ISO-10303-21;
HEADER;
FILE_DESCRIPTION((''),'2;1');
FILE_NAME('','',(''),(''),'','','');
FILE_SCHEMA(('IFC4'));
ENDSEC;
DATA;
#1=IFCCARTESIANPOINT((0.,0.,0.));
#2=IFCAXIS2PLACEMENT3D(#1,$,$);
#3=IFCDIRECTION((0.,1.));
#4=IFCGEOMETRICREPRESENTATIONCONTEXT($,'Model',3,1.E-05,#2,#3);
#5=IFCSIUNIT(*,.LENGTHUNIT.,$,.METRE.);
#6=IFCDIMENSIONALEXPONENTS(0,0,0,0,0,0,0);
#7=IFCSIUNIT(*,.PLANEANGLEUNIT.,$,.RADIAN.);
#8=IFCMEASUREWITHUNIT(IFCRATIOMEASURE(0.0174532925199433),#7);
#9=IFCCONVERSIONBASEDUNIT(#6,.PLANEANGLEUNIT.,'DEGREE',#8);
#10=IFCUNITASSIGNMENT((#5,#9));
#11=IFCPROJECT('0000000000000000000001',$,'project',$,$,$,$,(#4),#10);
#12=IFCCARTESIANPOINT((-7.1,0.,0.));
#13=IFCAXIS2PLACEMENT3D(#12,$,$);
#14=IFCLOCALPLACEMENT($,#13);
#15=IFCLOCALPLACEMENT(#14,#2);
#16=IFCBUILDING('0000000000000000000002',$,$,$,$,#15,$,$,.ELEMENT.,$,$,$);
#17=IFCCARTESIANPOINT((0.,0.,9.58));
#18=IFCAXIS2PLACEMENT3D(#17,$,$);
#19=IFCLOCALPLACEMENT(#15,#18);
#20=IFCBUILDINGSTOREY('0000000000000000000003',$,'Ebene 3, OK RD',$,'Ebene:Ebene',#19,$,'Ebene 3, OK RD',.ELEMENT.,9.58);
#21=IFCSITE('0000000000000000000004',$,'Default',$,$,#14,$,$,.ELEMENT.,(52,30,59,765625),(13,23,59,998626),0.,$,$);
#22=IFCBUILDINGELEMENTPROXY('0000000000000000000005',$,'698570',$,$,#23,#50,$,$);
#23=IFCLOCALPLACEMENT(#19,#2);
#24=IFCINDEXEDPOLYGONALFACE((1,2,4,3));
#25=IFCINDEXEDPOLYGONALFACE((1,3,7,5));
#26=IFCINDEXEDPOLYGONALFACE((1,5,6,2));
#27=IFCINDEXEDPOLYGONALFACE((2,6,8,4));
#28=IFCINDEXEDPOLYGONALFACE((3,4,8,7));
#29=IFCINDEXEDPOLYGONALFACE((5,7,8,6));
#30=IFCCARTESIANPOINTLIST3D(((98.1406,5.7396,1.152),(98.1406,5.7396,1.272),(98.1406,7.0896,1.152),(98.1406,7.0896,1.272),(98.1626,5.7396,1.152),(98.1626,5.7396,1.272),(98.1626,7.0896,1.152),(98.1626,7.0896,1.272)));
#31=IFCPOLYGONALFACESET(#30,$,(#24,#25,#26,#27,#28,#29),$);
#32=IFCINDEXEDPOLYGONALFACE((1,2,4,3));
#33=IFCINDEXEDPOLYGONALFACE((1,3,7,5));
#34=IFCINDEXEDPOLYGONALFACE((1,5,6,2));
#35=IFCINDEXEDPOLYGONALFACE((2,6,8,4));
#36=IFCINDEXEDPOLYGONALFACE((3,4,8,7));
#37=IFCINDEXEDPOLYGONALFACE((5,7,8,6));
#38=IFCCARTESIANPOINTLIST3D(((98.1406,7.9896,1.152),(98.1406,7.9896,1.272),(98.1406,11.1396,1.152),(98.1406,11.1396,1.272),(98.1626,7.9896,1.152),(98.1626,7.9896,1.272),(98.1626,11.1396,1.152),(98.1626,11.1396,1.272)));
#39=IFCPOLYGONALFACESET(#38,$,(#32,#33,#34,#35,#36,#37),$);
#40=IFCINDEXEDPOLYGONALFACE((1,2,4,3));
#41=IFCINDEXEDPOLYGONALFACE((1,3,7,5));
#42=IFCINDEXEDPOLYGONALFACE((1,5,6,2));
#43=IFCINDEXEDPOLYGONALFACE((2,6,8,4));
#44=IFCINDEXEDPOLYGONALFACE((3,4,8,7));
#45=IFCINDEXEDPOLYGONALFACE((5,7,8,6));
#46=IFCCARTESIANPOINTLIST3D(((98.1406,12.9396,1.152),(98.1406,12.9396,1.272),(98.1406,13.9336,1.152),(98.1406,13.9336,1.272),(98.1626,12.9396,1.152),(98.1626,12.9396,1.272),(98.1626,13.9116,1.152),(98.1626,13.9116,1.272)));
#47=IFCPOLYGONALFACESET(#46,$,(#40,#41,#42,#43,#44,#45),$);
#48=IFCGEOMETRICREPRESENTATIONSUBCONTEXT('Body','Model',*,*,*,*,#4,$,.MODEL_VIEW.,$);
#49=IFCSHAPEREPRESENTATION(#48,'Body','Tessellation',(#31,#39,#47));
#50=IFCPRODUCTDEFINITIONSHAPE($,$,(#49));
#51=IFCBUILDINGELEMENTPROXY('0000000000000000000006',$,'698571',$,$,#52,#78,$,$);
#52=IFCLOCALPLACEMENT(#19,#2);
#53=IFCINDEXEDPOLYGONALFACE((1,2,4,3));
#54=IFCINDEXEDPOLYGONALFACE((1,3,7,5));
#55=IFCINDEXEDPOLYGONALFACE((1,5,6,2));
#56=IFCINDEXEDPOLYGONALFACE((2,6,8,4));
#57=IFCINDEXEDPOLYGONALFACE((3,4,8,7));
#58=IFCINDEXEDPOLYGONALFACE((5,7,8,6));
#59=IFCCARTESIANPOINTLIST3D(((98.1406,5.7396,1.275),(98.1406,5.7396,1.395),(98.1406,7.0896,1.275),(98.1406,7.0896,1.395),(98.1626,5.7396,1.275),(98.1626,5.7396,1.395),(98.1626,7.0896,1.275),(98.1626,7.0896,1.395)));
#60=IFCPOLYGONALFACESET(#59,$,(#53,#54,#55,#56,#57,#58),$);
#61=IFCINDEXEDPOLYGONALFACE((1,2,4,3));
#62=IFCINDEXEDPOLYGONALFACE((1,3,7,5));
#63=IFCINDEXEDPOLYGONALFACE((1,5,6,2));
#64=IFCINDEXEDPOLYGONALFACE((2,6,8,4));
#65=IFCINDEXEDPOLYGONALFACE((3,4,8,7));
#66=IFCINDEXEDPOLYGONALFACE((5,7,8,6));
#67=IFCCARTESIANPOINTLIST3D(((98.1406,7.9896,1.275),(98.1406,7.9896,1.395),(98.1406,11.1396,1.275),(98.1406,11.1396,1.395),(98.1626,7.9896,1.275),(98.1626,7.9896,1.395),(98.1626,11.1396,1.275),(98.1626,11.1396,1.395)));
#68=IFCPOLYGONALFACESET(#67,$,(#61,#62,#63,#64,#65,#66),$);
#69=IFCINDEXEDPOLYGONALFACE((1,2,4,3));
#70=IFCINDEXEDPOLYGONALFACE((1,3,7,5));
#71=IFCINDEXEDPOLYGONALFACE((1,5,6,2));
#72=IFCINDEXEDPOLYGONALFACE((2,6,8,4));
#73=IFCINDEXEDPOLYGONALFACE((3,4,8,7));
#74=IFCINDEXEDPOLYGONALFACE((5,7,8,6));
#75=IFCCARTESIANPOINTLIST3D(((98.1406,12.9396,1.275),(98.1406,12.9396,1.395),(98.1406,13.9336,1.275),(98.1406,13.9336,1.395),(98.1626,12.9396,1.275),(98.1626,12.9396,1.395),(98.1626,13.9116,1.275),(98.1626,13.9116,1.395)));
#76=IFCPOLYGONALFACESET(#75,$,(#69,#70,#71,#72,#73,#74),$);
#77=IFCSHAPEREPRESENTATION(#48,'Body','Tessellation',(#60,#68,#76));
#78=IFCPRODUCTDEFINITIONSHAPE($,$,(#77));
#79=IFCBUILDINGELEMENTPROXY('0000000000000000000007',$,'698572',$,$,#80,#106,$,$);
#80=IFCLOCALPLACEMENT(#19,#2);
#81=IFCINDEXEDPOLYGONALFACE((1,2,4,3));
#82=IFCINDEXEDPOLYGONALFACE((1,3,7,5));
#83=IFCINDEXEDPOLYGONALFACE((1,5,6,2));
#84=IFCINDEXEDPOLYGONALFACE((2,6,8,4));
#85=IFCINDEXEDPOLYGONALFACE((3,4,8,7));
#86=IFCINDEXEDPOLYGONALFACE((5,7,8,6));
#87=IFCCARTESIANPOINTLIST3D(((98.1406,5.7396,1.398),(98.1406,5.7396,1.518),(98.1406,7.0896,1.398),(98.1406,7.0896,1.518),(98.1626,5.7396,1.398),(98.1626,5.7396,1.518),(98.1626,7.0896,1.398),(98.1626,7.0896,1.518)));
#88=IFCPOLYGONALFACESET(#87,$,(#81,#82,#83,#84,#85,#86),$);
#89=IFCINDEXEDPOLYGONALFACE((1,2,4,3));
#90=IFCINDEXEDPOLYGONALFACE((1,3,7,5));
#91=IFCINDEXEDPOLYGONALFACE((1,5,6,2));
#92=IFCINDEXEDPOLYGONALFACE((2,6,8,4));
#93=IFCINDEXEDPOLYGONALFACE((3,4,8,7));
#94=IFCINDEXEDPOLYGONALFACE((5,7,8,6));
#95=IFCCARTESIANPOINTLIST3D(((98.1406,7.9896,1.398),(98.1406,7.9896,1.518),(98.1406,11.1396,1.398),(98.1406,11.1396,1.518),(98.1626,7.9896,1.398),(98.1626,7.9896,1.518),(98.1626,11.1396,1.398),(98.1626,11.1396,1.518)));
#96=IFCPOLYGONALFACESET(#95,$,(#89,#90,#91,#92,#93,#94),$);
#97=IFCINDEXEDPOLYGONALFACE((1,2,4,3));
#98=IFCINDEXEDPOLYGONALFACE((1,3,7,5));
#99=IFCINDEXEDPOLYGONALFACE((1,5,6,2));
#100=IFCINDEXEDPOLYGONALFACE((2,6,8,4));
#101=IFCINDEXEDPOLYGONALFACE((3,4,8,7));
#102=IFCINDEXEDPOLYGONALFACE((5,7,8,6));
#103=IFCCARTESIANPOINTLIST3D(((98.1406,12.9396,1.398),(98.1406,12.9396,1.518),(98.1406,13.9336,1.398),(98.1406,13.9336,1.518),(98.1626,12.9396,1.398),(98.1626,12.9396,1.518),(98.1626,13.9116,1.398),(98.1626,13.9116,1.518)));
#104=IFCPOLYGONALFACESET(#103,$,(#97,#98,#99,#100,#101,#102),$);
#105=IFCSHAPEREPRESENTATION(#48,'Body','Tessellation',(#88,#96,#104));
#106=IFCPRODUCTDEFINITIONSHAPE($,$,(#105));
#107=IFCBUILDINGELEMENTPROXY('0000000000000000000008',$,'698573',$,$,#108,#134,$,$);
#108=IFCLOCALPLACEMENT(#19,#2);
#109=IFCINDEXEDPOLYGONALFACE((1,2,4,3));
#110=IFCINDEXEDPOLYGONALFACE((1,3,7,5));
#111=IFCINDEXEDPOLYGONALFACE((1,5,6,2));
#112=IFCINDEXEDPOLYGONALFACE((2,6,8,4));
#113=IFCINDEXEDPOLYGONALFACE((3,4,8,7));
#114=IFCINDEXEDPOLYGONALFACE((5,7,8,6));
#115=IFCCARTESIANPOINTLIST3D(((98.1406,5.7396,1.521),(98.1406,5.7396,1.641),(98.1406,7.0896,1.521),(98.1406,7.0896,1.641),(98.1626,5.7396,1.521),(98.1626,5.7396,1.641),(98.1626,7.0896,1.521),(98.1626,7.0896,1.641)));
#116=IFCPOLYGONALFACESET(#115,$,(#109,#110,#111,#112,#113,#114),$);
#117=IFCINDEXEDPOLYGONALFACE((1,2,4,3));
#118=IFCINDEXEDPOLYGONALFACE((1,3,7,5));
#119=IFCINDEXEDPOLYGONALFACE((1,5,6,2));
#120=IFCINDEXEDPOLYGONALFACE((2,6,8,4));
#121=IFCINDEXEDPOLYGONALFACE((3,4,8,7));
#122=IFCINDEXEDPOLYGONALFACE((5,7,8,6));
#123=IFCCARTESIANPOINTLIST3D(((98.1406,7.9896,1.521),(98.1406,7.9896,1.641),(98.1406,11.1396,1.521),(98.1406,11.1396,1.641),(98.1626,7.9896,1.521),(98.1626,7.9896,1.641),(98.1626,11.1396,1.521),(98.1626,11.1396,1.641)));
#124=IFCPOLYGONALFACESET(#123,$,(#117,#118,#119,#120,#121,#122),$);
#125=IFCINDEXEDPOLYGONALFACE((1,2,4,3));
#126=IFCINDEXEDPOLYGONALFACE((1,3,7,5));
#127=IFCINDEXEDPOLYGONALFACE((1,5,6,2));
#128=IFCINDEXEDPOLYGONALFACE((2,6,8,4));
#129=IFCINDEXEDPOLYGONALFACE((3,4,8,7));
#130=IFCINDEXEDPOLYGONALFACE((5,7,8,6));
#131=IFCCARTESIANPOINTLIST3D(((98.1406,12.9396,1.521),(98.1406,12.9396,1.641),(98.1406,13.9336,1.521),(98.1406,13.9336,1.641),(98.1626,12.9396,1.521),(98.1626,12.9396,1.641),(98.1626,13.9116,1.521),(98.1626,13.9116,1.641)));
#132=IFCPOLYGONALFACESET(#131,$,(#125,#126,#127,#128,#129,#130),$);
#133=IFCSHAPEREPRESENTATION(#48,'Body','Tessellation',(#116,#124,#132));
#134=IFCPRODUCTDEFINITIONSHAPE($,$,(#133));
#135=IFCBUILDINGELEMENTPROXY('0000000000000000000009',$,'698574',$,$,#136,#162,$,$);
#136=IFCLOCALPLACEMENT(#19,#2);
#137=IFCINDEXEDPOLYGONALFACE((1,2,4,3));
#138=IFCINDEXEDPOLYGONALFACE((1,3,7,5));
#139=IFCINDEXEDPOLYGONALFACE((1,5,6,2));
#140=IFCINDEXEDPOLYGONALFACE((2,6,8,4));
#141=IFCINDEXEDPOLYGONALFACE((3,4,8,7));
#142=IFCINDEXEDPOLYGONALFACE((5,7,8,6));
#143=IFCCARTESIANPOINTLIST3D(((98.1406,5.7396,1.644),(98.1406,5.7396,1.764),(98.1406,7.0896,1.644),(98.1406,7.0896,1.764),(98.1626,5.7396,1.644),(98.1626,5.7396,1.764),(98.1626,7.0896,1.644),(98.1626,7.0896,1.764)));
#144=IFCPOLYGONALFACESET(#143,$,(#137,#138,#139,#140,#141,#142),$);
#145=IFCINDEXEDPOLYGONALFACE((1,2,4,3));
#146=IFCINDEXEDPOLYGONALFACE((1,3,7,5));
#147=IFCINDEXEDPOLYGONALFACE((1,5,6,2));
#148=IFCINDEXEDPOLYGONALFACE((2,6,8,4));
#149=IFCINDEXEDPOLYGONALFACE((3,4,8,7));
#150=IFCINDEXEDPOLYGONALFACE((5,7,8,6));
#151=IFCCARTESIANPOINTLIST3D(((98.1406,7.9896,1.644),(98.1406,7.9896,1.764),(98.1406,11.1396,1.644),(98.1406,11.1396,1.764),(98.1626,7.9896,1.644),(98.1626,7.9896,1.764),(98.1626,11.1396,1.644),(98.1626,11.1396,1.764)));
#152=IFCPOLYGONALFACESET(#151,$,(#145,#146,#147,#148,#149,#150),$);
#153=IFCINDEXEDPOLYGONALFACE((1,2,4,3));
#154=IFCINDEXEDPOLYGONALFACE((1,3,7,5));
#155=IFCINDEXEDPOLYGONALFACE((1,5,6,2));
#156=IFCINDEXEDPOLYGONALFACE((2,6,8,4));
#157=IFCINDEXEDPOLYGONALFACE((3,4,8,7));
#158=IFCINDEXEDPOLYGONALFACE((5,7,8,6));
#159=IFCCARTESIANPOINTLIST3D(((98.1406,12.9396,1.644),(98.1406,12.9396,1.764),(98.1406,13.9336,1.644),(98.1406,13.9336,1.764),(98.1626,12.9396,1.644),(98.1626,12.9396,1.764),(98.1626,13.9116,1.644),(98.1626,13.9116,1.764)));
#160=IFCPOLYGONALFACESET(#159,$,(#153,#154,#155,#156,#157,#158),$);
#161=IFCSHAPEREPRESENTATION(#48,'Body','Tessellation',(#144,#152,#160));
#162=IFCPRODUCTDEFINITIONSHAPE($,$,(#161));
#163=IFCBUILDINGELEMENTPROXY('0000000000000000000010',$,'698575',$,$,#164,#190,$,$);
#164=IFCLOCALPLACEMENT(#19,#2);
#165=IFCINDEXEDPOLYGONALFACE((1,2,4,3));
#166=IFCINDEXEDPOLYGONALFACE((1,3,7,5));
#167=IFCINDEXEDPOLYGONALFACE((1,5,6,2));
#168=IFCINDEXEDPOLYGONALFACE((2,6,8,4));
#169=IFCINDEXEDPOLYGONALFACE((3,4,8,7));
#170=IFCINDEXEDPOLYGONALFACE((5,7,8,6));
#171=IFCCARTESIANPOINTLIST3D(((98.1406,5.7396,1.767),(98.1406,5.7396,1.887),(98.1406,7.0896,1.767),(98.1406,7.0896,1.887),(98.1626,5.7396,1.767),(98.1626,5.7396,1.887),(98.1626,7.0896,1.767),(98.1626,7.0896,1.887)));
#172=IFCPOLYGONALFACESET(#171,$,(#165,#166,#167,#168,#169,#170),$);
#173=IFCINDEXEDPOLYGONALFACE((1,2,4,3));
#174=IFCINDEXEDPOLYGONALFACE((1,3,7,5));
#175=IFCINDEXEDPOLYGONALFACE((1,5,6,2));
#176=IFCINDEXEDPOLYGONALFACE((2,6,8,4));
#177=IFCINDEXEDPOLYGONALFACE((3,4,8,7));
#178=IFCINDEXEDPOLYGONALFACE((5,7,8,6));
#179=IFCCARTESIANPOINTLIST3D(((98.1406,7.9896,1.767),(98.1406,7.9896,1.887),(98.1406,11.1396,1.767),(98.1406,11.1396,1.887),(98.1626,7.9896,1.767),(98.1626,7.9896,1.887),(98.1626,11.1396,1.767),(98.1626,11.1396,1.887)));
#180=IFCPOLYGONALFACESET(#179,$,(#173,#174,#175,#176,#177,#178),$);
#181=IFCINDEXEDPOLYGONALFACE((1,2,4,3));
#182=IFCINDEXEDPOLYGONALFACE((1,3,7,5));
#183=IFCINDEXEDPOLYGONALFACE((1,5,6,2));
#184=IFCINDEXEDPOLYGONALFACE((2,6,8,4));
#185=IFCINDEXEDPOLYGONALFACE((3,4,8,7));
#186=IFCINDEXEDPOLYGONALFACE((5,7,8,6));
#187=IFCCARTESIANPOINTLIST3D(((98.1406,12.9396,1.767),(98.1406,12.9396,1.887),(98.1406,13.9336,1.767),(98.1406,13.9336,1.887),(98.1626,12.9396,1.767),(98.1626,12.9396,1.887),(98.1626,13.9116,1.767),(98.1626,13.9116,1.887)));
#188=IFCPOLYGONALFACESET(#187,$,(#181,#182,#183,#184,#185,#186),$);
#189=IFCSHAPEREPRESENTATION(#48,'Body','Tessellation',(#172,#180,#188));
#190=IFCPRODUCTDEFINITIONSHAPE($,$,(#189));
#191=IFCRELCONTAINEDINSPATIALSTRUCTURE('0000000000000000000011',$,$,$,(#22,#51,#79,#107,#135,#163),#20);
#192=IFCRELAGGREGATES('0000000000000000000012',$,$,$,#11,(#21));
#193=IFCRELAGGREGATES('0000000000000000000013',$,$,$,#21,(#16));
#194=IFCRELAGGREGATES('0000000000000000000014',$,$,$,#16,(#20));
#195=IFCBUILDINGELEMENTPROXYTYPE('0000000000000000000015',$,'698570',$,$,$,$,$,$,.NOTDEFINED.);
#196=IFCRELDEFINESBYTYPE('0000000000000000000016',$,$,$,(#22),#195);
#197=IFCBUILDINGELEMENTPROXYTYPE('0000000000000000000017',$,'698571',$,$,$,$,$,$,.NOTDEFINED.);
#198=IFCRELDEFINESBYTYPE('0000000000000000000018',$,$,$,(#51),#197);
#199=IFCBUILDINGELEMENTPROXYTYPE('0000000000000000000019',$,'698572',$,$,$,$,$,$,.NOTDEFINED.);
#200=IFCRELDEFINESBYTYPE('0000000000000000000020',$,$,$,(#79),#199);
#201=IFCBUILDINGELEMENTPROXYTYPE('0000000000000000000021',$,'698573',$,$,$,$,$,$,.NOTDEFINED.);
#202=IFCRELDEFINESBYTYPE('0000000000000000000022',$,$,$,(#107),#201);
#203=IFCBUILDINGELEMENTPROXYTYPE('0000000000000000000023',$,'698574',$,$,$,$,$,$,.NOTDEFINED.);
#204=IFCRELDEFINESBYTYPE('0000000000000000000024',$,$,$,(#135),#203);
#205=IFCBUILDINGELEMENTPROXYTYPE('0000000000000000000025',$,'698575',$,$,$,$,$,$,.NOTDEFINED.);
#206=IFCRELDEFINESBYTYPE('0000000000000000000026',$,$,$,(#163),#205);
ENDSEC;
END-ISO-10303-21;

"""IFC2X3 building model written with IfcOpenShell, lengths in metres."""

from ifc_helpers import new_model, entity, si_unit, converted_unit, direction, frame, frame_2d, origin, origin_2d_with_axis, place, context, subcontext, project, spatial, polyline, rectangle, outline, extrude, type_object, element, save


model = new_model("IFC2X3")

# Units and contexts
model_context = context("Model", 3, precision=1e-05, world=origin(), true_north=direction((0.0, 1.0)))
body_context = subcontext(model_context, "Body", "Model", "MODEL_VIEW")
ifc_project = project(units=[si_unit("LENGTHUNIT", "METRE"), converted_unit("PLANEANGLEUNIT", "DEGREE", entity("IfcRatioMeasure", 0.0174532925199433), si_unit("PLANEANGLEUNIT", "RADIAN"), dimensions=[0, 0, 0, 0, 0, 0, 0])], contexts=[model_context])

# Site, building, storey
site_placement = place(None, frame((-7.1, 0.0, 0.0)))
site = spatial("IfcSite", under=ifc_project, at=site_placement, Name="Default", CompositionType="ELEMENT", RefLatitude=(52, 30, 59, 765625), RefLongitude=(13, 23, 59, 998626), RefElevation=0.0)
building_placement = place(site_placement, origin())
building = spatial("IfcBuilding", under=site, at=building_placement, CompositionType="ELEMENT")
storey_placement = place(building_placement, frame((0.0, 0.0, 9.58)))
storey = spatial("IfcBuildingStorey", under=building, at=storey_placement, Name="Ebene 3, OK RD", ObjectType="Ebene:Ebene", LongName="Ebene 3, OK RD", CompositionType="ELEMENT", Elevation=9.58)

# Building element proxies
building_element_proxy_type_1 = type_object("IfcBuildingElementProxyType", Name="698570", PredefinedType="NOTDEFINED")
proxy_1_placement = place(storey_placement, origin())
element("IfcBuildingElementProxy", 1, at=proxy_1_placement, inside=storey, type_object=building_element_proxy_type_1, Name="698570", context=body_context, shape_type="SweptSolid", body=[
    extrude(rectangle(XDim=1.35, YDim=0.022, at=frame_2d((0.0, 0.0), x_axis=(1.0, 0.0))), frame((98.1516, 6.4146, 1.152), z_axis=(0.0, 0.0, 1.0), x_axis=(0.0, 1.0, 0.0)), (0.0, 0.0, 1.0), 0.12),
    extrude(rectangle(XDim=3.15, YDim=0.022, at=origin_2d_with_axis()), frame((98.1516, 9.5646, 1.152), z_axis=(0.0, 0.0, 1.0), x_axis=(0.0, 1.0, 0.0)), (0.0, 0.0, 1.0), 0.12),
    extrude(outline(polyline([(-0.4915, -0.011), (0.4805, -0.011), (0.5025, 0.011), (-0.4915, 0.011), (-0.4915, -0.011)])), frame((98.1516, 13.4311, 1.152), z_axis=(0.0, 0.0, 1.0), x_axis=(0.0, 1.0, 0.0)), (0.0, 0.0, 1.0), 0.12),
])
building_element_proxy_type_2 = type_object("IfcBuildingElementProxyType", Name="698571", PredefinedType="NOTDEFINED")
proxy_2_placement = place(storey_placement, origin())
element("IfcBuildingElementProxy", 2, at=proxy_2_placement, inside=storey, type_object=building_element_proxy_type_2, Name="698571", context=body_context, shape_type="SweptSolid", body=[
    extrude(rectangle(XDim=1.35, YDim=0.022, at=frame_2d((0.0, 0.0), x_axis=(1.0, 0.0))), frame((98.1516, 6.4146, 1.275), z_axis=(0.0, 0.0, 1.0), x_axis=(0.0, 1.0, 0.0)), (0.0, 0.0, 1.0), 0.12),
    extrude(rectangle(XDim=3.15, YDim=0.022, at=origin_2d_with_axis()), frame((98.1516, 9.5646, 1.275), z_axis=(0.0, 0.0, 1.0), x_axis=(0.0, 1.0, 0.0)), (0.0, 0.0, 1.0), 0.12),
    extrude(outline(polyline([(-0.4915, -0.011), (0.4805, -0.011), (0.5025, 0.011), (-0.4915, 0.011), (-0.4915, -0.011)])), frame((98.1516, 13.4311, 1.275), z_axis=(0.0, 0.0, 1.0), x_axis=(0.0, 1.0, 0.0)), (0.0, 0.0, 1.0), 0.12),
])
building_element_proxy_type_3 = type_object("IfcBuildingElementProxyType", Name="698572", PredefinedType="NOTDEFINED")
proxy_3_placement = place(storey_placement, origin())
element("IfcBuildingElementProxy", 3, at=proxy_3_placement, inside=storey, type_object=building_element_proxy_type_3, Name="698572", context=body_context, shape_type="SweptSolid", body=[
    extrude(rectangle(XDim=1.35, YDim=0.022, at=frame_2d((0.0, 0.0), x_axis=(1.0, 0.0))), frame((98.1516, 6.4146, 1.398), z_axis=(0.0, 0.0, 1.0), x_axis=(0.0, 1.0, 0.0)), (0.0, 0.0, 1.0), 0.12),
    extrude(rectangle(XDim=3.15, YDim=0.022, at=frame_2d((0.0, 0.0), x_axis=(1.0, 0.0))), frame((98.1516, 9.5646, 1.398), z_axis=(0.0, 0.0, 1.0), x_axis=(0.0, 1.0, 0.0)), (0.0, 0.0, 1.0), 0.12),
    extrude(outline(polyline([(-0.4915, -0.011), (0.4805, -0.011), (0.5025, 0.011), (-0.4915, 0.011), (-0.4915, -0.011)])), frame((98.1516, 13.4311, 1.398), z_axis=(0.0, 0.0, 1.0), x_axis=(0.0, 1.0, 0.0)), (0.0, 0.0, 1.0), 0.12),
])
building_element_proxy_type_4 = type_object("IfcBuildingElementProxyType", Name="698573", PredefinedType="NOTDEFINED")
proxy_4_placement = place(storey_placement, origin())
element("IfcBuildingElementProxy", 4, at=proxy_4_placement, inside=storey, type_object=building_element_proxy_type_4, Name="698573", context=body_context, shape_type="SweptSolid", body=[
    extrude(rectangle(XDim=1.35, YDim=0.022, at=frame_2d((0.0, 0.0), x_axis=(1.0, 0.0))), frame((98.1516, 6.4146, 1.521), z_axis=(0.0, 0.0, 1.0), x_axis=(0.0, 1.0, 0.0)), (0.0, 0.0, 1.0), 0.12),
    extrude(rectangle(XDim=3.15, YDim=0.022, at=frame_2d((0.0, 0.0), x_axis=(1.0, 0.0))), frame((98.1516, 9.5646, 1.521), z_axis=(0.0, 0.0, 1.0), x_axis=(0.0, 1.0, 0.0)), (0.0, 0.0, 1.0), 0.12),
    extrude(outline(polyline([(-0.4915, -0.011), (0.4805, -0.011), (0.5025, 0.011), (-0.4915, 0.011), (-0.4915, -0.011)])), frame((98.1516, 13.4311, 1.521), z_axis=(0.0, 0.0, 1.0), x_axis=(0.0, 1.0, 0.0)), (0.0, 0.0, 1.0), 0.12),
])
building_element_proxy_type_5 = type_object("IfcBuildingElementProxyType", Name="698574", PredefinedType="NOTDEFINED")
proxy_5_placement = place(storey_placement, origin())
element("IfcBuildingElementProxy", 5, at=proxy_5_placement, inside=storey, type_object=building_element_proxy_type_5, Name="698574", context=body_context, shape_type="SweptSolid", body=[
    extrude(rectangle(XDim=1.35, YDim=0.022, at=frame_2d((0.0, 0.0), x_axis=(1.0, 0.0))), frame((98.1516, 6.4146, 1.644), z_axis=(0.0, 0.0, 1.0), x_axis=(0.0, 1.0, 0.0)), (0.0, 0.0, 1.0), 0.12),
    extrude(rectangle(XDim=3.15, YDim=0.022, at=origin_2d_with_axis()), frame((98.1516, 9.5646, 1.644), z_axis=(0.0, 0.0, 1.0), x_axis=(0.0, 1.0, 0.0)), (0.0, 0.0, 1.0), 0.12),
    extrude(outline(polyline([(-0.4915, -0.011), (0.4805, -0.011), (0.5025, 0.011), (-0.4915, 0.011), (-0.4915, -0.011)])), frame((98.1516, 13.4311, 1.644), z_axis=(0.0, 0.0, 1.0), x_axis=(0.0, 1.0, 0.0)), (0.0, 0.0, 1.0), 0.12),
])
building_element_proxy_type_6 = type_object("IfcBuildingElementProxyType", Name="698575", PredefinedType="NOTDEFINED")
proxy_6_placement = place(storey_placement, origin())
element("IfcBuildingElementProxy", 6, at=proxy_6_placement, inside=storey, type_object=building_element_proxy_type_6, Name="698575", context=body_context, shape_type="SweptSolid", body=[
    extrude(rectangle(XDim=1.35, YDim=0.022, at=frame_2d((0.0, 0.0), x_axis=(1.0, 0.0))), frame((98.1516, 6.4146, 1.767), z_axis=(0.0, 0.0, 1.0), x_axis=(0.0, 1.0, 0.0)), (0.0, 0.0, 1.0), 0.12),
    extrude(rectangle(XDim=3.15, YDim=0.022, at=origin_2d_with_axis()), frame((98.1516, 9.5646, 1.767), z_axis=(0.0, 0.0, 1.0), x_axis=(0.0, 1.0, 0.0)), (0.0, 0.0, 1.0), 0.12),
    extrude(outline(polyline([(-0.4915, -0.011), (0.4805, -0.011), (0.5025, 0.011), (-0.4915, 0.011), (-0.4915, -0.011)])), frame((98.1516, 13.4311, 1.767), z_axis=(0.0, 0.0, 1.0), x_axis=(0.0, 1.0, 0.0)), (0.0, 0.0, 1.0), 0.12),
])

save(model, "model.ifc")
